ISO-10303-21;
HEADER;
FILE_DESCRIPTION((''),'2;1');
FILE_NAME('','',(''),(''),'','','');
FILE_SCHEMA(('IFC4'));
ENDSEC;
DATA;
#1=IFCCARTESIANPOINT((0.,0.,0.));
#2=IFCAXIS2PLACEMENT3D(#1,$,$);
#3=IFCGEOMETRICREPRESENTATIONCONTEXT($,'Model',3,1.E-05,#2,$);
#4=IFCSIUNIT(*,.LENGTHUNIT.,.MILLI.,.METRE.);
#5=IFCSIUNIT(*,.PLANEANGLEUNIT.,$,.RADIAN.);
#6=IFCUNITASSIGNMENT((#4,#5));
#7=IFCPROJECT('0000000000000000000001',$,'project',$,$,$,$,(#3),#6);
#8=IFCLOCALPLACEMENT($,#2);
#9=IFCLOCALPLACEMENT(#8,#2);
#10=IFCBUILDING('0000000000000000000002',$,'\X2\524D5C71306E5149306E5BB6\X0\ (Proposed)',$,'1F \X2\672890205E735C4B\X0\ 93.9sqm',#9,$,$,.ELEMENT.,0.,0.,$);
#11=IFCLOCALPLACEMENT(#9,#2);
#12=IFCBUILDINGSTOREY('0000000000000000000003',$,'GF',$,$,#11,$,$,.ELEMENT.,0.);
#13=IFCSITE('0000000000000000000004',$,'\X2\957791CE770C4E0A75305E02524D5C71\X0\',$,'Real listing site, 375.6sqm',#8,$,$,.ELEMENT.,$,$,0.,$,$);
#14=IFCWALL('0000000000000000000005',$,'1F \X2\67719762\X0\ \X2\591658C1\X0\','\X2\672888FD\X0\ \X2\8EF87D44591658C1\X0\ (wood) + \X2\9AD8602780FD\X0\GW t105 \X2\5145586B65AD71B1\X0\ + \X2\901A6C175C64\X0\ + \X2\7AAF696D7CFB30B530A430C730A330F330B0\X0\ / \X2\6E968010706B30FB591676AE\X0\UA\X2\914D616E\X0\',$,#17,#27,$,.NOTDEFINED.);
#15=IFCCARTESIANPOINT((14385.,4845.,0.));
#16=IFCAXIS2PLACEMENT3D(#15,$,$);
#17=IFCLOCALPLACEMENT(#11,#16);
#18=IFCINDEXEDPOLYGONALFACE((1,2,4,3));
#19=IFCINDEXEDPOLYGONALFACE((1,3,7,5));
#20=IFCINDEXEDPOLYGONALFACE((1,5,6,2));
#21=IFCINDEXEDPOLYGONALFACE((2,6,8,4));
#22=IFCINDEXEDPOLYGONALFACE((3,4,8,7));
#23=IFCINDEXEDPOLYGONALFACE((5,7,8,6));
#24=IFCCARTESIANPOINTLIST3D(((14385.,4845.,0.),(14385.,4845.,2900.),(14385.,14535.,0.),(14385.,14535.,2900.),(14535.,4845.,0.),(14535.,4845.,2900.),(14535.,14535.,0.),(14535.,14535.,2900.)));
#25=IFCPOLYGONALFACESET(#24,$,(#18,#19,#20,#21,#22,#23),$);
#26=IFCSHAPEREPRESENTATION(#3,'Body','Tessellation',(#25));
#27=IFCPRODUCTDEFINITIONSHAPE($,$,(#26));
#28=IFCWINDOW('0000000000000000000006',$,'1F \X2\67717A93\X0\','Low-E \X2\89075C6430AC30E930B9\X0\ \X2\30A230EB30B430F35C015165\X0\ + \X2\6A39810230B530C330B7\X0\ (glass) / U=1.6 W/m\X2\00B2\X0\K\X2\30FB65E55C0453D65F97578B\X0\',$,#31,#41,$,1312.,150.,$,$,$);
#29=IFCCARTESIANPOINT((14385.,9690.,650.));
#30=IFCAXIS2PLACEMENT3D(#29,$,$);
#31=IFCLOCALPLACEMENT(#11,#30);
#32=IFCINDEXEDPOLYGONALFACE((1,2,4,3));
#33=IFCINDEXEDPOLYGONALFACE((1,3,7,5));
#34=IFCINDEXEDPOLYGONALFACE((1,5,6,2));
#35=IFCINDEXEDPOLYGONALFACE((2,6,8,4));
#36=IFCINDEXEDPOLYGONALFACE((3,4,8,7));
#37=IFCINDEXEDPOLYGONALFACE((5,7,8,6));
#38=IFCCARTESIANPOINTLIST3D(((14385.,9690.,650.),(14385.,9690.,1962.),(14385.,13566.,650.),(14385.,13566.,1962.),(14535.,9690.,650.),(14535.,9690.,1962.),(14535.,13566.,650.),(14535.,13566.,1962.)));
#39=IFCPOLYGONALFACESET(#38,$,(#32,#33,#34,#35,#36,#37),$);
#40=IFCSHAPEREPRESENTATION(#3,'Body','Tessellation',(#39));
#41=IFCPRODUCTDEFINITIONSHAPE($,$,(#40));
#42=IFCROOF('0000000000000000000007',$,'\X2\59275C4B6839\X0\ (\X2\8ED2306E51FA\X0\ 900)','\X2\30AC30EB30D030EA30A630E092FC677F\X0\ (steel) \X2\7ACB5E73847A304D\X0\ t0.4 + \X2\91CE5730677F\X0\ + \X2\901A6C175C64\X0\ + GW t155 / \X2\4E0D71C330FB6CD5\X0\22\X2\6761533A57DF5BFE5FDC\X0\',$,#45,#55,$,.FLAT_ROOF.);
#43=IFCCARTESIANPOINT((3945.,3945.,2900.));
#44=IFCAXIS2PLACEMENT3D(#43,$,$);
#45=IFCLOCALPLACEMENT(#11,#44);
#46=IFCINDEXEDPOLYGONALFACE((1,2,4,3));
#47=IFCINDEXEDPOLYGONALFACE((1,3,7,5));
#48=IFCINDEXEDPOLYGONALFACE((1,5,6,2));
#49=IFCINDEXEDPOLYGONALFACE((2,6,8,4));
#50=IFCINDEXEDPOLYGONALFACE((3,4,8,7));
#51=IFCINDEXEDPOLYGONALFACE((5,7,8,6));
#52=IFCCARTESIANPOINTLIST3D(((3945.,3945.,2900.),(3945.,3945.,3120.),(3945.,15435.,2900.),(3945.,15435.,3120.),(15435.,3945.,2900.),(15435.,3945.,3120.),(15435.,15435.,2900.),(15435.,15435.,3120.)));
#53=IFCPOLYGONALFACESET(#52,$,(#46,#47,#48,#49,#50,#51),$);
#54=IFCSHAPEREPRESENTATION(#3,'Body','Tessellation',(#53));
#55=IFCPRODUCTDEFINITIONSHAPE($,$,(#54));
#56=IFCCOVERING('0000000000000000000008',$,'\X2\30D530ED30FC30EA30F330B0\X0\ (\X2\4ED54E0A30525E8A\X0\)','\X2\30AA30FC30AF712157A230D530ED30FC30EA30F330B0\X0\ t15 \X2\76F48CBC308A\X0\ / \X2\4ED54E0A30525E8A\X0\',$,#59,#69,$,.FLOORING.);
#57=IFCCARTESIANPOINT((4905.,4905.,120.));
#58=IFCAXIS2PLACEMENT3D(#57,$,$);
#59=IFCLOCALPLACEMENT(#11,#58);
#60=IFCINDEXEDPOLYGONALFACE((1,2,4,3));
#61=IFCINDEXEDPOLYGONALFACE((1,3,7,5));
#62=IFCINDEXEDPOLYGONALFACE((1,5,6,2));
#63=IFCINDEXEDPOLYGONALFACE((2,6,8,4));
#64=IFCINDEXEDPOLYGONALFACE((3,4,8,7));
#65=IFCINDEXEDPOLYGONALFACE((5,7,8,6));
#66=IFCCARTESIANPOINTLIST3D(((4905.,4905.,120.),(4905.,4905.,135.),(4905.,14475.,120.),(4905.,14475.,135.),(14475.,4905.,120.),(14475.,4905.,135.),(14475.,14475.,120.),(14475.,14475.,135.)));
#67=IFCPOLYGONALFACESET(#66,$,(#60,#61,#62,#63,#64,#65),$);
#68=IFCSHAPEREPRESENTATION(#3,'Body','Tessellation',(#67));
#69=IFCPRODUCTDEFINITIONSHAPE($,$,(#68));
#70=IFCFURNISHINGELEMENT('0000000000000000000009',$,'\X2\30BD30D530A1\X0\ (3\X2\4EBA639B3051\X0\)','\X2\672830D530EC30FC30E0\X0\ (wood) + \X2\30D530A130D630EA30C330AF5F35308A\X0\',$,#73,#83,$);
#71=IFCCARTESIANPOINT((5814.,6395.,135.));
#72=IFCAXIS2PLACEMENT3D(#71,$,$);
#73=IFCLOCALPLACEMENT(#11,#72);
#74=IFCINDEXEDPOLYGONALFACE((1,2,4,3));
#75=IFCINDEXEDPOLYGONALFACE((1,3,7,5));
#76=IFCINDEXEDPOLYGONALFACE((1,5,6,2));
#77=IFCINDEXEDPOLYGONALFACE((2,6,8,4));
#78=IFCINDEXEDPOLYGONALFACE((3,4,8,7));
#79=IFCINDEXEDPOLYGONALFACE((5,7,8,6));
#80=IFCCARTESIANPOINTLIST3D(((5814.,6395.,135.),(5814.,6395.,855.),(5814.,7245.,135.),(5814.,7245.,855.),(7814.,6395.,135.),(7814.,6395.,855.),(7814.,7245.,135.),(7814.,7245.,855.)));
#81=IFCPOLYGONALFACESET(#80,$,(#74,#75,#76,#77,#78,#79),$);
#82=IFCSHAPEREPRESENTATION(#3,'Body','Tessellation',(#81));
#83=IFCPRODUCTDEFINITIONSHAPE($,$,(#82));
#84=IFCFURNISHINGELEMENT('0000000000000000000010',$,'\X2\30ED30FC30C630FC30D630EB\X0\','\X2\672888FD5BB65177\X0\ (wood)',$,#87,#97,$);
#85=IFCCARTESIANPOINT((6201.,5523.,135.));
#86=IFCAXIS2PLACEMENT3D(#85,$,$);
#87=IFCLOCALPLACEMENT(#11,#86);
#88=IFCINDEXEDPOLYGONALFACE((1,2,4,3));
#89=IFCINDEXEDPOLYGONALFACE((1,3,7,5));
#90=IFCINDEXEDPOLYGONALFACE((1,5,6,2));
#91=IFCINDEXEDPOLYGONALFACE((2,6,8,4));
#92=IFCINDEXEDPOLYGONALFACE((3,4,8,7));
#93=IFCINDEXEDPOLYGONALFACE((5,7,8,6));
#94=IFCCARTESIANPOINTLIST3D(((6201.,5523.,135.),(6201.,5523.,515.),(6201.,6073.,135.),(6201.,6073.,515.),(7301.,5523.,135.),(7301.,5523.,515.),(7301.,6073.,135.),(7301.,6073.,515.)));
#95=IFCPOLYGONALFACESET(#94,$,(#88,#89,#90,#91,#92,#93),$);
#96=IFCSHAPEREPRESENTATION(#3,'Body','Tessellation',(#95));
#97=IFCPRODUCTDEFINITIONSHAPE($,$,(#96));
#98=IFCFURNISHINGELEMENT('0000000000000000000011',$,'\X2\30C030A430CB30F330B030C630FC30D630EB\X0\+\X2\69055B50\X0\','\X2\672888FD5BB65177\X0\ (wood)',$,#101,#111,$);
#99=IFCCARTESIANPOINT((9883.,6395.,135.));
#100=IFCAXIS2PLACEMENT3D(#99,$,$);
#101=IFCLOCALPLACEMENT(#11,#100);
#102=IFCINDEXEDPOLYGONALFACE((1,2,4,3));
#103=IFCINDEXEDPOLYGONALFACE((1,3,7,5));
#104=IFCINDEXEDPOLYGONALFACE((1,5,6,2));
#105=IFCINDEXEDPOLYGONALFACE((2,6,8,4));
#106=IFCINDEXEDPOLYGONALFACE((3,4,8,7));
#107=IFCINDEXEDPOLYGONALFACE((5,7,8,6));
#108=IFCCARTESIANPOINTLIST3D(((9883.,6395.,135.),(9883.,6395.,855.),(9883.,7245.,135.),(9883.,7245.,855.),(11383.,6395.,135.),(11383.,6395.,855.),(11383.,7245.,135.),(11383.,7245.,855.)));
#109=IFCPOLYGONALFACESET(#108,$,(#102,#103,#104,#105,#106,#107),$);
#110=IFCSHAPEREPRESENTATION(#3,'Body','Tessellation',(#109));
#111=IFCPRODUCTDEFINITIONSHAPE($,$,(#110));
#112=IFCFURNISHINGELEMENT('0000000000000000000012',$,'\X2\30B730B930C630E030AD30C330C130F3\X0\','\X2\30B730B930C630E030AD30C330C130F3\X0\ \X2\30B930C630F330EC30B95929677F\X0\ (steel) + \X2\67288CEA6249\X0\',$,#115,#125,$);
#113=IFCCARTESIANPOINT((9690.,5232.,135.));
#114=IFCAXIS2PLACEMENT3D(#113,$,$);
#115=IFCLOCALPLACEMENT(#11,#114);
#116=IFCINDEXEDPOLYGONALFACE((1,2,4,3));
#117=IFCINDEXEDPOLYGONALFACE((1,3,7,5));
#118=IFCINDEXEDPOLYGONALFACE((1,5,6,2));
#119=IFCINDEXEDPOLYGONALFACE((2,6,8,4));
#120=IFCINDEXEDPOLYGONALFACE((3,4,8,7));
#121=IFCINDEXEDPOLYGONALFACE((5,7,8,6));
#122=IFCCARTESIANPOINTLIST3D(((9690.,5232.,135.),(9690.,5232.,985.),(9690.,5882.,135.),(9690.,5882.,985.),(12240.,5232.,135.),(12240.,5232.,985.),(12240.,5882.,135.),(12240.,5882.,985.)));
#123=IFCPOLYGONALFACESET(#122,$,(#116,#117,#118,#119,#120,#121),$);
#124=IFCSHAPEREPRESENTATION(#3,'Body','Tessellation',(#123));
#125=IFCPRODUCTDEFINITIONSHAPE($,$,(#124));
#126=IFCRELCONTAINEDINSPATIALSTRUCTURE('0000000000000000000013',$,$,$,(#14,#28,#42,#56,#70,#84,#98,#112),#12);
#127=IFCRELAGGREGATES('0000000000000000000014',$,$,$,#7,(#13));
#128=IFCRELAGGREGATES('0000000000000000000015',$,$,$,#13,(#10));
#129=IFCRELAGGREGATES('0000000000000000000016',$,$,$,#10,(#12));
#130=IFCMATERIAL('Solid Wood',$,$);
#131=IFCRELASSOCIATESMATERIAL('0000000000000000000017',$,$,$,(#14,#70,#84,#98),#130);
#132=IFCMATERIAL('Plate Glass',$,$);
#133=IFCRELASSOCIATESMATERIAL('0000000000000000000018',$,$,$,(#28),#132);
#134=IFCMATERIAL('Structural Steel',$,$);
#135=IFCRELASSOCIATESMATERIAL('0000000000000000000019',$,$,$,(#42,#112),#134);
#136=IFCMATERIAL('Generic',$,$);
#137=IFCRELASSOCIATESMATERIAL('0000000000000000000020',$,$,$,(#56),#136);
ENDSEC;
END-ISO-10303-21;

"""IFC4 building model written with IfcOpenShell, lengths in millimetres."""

from ifc_helpers import new_model, si_unit, frame, frame_2d, origin, place, context, project, spatial, rectangle, extrude, material, element, fill, save


model = new_model("IFC4")

# Units and contexts
model_context = context("Model", 3, precision=1e-05, world=origin())
ifc_project = project(units=[si_unit("LENGTHUNIT", "METRE", prefix="MILLI"), si_unit("PLANEANGLEUNIT", "RADIAN")], contexts=[model_context])

# Site, building, storey
site_placement = place(None, origin())
site = spatial("IfcSite", under=ifc_project, at=site_placement, Name="長野県上田市前山", ObjectType="Real listing site, 375.6sqm", CompositionType="ELEMENT", RefElevation=0.0)
building_placement = place(site_placement, origin())
building = spatial("IfcBuilding", under=site, at=building_placement, Name="前山の光の家 (Proposed)", ObjectType="1F 木造平屋 93.9sqm", CompositionType="ELEMENT", ElevationOfRefHeight=0.0, ElevationOfTerrain=0.0)
storey_placement = place(building_placement, origin())
storey = spatial("IfcBuildingStorey", under=building, at=storey_placement, Name="GF", CompositionType="ELEMENT", Elevation=0.0)

# Shared definitions
ifc_material_1 = material(Name="Solid Wood")

# Shared definitions
ifc_material_2 = material(Name="Plate Glass")

# Wall, opening, window
wall_1_placement = place(storey_placement, frame((14385.0, 4845.0, 0.0)))
wall_1 = element("IfcWall", 1, at=wall_1_placement, inside=storey, material=ifc_material_1, Name="1F 東面 外壁", Description="木製 軸組外壁 (wood) + 高性能GW t105 充填断熱 + 通気層 + 窯業系サイディング / 準耐火・外皮UA配慮", PredefinedType="NOTDEFINED", context=model_context, shape_type="SweptSolid", body=[
    extrude(rectangle(XDim=150.0, YDim=9690.0, at=frame_2d((75.0, 4845.0))), frame((14385.0, 4845.0, 0.0)), (0.0, 0.0, 1.0), 2900.0),
])
opening_1_placement = place(storey_placement, frame((14385.0, 9690.0, 650.0)))
opening_1 = element("IfcOpeningElement", 2, at=opening_1_placement, cuts=wall_1, PredefinedType="NOTDEFINED", context=model_context, shape_type="SweptSolid", body=[
    extrude(rectangle(XDim=150.0, YDim=3876.0, at=frame_2d((75.0, 1938.0))), frame((14385.0, 9690.0, 650.0)), (0.0, 0.0, 1.0), 1312.0),
])
window_1_placement = place(storey_placement, frame((14385.0, 9690.0, 650.0)))
window_1 = element("IfcWindow", 3, at=window_1_placement, inside=storey, material=ifc_material_2, Name="1F 東窓", Description="Low-E 複層ガラス アルゴン封入 + 樹脂サッシ (glass) / U=1.6 W/m²K・日射取得型", OverallHeight=1312.0, OverallWidth=150.0, context=model_context, shape_type="SweptSolid", body=[
    extrude(rectangle(XDim=150.0, YDim=3876.0, at=frame_2d((75.0, 1938.0))), frame((14385.0, 9690.0, 650.0)), (0.0, 0.0, 1.0), 1312.0),
])
fill(opening_1, window_1)

# Roof
ifc_material_3 = material(Name="Structural Steel")
roof_placement = place(storey_placement, frame((3945.0, 3945.0, 2900.0)))
element("IfcRoof", 4, at=roof_placement, inside=storey, material=ifc_material_3, Name="大屋根 (軒の出 900)", Description="ガルバリウム鋼板 (steel) 立平葺き t0.4 + 野地板 + 通気層 + GW t155 / 不燃・法22条区域対応", PredefinedType="FLAT_ROOF", context=model_context, shape_type="SweptSolid", body=[
    extrude(rectangle(XDim=11490.0, YDim=11490.0, at=frame_2d((5745.0, 5745.0))), frame((3945.0, 3945.0, 2900.0)), (0.0, 0.0, 1.0), 220.0),
])

# Covering
ifc_material_4 = material(Name="Generic")
covering_placement = place(storey_placement, frame((4905.0, 4905.0, 120.0)))
element("IfcCovering", 5, at=covering_placement, inside=storey, material=ifc_material_4, Name="フローリング (仕上げ床)", Description="オーク無垢フローリング t15 直貼り / 仕上げ床", PredefinedType="FLOORING", context=model_context, shape_type="SweptSolid", body=[
    extrude(rectangle(XDim=9570.0, YDim=9570.0, at=frame_2d((4785.0, 4785.0))), frame((4905.0, 4905.0, 120.0)), (0.0, 0.0, 1.0), 15.0),
])

# Furnishing elements
furnishing_1_placement = place(storey_placement, frame((5814.0, 6395.0, 135.0)))
element("IfcFurnishingElement", 6, at=furnishing_1_placement, inside=storey, material=ifc_material_1, Name="ソファ (3人掛け)", Description="木フレーム (wood) + ファブリック張り", context=model_context, shape_type="SweptSolid", body=[
    extrude(rectangle(XDim=2000.0, YDim=850.0, at=frame_2d((1000.0, 425.0))), frame((5814.0, 6395.0, 135.0)), (0.0, 0.0, 1.0), 720.0),
])
furnishing_2_placement = place(storey_placement, frame((6201.0, 5523.0, 135.0)))
element("IfcFurnishingElement", 7, at=furnishing_2_placement, inside=storey, material=ifc_material_1, Name="ローテーブル", Description="木製家具 (wood)", context=model_context, shape_type="SweptSolid", body=[
    extrude(rectangle(XDim=1100.0, YDim=550.0, at=frame_2d((550.0, 275.0))), frame((6201.0, 5523.0, 135.0)), (0.0, 0.0, 1.0), 380.0),
])
furnishing_3_placement = place(storey_placement, frame((9883.0, 6395.0, 135.0)))
element("IfcFurnishingElement", 8, at=furnishing_3_placement, inside=storey, material=ifc_material_1, Name="ダイニングテーブル+椅子", Description="木製家具 (wood)", context=model_context, shape_type="SweptSolid", body=[
    extrude(rectangle(XDim=1500.0, YDim=850.0, at=frame_2d((750.0, 425.0))), frame((9883.0, 6395.0, 135.0)), (0.0, 0.0, 1.0), 720.0),
])
furnishing_4_placement = place(storey_placement, frame((9690.0, 5232.0, 135.0)))
element("IfcFurnishingElement", 9, at=furnishing_4_placement, inside=storey, material=ifc_material_3, Name="システムキッチン", Description="システムキッチン ステンレス天板 (steel) + 木質扉", context=model_context, shape_type="SweptSolid", body=[
    extrude(rectangle(XDim=2550.0, YDim=650.0, at=frame_2d((1275.0, 325.0))), frame((9690.0, 5232.0, 135.0)), (0.0, 0.0, 1.0), 850.0),
])

save(model, "model.ifc")
